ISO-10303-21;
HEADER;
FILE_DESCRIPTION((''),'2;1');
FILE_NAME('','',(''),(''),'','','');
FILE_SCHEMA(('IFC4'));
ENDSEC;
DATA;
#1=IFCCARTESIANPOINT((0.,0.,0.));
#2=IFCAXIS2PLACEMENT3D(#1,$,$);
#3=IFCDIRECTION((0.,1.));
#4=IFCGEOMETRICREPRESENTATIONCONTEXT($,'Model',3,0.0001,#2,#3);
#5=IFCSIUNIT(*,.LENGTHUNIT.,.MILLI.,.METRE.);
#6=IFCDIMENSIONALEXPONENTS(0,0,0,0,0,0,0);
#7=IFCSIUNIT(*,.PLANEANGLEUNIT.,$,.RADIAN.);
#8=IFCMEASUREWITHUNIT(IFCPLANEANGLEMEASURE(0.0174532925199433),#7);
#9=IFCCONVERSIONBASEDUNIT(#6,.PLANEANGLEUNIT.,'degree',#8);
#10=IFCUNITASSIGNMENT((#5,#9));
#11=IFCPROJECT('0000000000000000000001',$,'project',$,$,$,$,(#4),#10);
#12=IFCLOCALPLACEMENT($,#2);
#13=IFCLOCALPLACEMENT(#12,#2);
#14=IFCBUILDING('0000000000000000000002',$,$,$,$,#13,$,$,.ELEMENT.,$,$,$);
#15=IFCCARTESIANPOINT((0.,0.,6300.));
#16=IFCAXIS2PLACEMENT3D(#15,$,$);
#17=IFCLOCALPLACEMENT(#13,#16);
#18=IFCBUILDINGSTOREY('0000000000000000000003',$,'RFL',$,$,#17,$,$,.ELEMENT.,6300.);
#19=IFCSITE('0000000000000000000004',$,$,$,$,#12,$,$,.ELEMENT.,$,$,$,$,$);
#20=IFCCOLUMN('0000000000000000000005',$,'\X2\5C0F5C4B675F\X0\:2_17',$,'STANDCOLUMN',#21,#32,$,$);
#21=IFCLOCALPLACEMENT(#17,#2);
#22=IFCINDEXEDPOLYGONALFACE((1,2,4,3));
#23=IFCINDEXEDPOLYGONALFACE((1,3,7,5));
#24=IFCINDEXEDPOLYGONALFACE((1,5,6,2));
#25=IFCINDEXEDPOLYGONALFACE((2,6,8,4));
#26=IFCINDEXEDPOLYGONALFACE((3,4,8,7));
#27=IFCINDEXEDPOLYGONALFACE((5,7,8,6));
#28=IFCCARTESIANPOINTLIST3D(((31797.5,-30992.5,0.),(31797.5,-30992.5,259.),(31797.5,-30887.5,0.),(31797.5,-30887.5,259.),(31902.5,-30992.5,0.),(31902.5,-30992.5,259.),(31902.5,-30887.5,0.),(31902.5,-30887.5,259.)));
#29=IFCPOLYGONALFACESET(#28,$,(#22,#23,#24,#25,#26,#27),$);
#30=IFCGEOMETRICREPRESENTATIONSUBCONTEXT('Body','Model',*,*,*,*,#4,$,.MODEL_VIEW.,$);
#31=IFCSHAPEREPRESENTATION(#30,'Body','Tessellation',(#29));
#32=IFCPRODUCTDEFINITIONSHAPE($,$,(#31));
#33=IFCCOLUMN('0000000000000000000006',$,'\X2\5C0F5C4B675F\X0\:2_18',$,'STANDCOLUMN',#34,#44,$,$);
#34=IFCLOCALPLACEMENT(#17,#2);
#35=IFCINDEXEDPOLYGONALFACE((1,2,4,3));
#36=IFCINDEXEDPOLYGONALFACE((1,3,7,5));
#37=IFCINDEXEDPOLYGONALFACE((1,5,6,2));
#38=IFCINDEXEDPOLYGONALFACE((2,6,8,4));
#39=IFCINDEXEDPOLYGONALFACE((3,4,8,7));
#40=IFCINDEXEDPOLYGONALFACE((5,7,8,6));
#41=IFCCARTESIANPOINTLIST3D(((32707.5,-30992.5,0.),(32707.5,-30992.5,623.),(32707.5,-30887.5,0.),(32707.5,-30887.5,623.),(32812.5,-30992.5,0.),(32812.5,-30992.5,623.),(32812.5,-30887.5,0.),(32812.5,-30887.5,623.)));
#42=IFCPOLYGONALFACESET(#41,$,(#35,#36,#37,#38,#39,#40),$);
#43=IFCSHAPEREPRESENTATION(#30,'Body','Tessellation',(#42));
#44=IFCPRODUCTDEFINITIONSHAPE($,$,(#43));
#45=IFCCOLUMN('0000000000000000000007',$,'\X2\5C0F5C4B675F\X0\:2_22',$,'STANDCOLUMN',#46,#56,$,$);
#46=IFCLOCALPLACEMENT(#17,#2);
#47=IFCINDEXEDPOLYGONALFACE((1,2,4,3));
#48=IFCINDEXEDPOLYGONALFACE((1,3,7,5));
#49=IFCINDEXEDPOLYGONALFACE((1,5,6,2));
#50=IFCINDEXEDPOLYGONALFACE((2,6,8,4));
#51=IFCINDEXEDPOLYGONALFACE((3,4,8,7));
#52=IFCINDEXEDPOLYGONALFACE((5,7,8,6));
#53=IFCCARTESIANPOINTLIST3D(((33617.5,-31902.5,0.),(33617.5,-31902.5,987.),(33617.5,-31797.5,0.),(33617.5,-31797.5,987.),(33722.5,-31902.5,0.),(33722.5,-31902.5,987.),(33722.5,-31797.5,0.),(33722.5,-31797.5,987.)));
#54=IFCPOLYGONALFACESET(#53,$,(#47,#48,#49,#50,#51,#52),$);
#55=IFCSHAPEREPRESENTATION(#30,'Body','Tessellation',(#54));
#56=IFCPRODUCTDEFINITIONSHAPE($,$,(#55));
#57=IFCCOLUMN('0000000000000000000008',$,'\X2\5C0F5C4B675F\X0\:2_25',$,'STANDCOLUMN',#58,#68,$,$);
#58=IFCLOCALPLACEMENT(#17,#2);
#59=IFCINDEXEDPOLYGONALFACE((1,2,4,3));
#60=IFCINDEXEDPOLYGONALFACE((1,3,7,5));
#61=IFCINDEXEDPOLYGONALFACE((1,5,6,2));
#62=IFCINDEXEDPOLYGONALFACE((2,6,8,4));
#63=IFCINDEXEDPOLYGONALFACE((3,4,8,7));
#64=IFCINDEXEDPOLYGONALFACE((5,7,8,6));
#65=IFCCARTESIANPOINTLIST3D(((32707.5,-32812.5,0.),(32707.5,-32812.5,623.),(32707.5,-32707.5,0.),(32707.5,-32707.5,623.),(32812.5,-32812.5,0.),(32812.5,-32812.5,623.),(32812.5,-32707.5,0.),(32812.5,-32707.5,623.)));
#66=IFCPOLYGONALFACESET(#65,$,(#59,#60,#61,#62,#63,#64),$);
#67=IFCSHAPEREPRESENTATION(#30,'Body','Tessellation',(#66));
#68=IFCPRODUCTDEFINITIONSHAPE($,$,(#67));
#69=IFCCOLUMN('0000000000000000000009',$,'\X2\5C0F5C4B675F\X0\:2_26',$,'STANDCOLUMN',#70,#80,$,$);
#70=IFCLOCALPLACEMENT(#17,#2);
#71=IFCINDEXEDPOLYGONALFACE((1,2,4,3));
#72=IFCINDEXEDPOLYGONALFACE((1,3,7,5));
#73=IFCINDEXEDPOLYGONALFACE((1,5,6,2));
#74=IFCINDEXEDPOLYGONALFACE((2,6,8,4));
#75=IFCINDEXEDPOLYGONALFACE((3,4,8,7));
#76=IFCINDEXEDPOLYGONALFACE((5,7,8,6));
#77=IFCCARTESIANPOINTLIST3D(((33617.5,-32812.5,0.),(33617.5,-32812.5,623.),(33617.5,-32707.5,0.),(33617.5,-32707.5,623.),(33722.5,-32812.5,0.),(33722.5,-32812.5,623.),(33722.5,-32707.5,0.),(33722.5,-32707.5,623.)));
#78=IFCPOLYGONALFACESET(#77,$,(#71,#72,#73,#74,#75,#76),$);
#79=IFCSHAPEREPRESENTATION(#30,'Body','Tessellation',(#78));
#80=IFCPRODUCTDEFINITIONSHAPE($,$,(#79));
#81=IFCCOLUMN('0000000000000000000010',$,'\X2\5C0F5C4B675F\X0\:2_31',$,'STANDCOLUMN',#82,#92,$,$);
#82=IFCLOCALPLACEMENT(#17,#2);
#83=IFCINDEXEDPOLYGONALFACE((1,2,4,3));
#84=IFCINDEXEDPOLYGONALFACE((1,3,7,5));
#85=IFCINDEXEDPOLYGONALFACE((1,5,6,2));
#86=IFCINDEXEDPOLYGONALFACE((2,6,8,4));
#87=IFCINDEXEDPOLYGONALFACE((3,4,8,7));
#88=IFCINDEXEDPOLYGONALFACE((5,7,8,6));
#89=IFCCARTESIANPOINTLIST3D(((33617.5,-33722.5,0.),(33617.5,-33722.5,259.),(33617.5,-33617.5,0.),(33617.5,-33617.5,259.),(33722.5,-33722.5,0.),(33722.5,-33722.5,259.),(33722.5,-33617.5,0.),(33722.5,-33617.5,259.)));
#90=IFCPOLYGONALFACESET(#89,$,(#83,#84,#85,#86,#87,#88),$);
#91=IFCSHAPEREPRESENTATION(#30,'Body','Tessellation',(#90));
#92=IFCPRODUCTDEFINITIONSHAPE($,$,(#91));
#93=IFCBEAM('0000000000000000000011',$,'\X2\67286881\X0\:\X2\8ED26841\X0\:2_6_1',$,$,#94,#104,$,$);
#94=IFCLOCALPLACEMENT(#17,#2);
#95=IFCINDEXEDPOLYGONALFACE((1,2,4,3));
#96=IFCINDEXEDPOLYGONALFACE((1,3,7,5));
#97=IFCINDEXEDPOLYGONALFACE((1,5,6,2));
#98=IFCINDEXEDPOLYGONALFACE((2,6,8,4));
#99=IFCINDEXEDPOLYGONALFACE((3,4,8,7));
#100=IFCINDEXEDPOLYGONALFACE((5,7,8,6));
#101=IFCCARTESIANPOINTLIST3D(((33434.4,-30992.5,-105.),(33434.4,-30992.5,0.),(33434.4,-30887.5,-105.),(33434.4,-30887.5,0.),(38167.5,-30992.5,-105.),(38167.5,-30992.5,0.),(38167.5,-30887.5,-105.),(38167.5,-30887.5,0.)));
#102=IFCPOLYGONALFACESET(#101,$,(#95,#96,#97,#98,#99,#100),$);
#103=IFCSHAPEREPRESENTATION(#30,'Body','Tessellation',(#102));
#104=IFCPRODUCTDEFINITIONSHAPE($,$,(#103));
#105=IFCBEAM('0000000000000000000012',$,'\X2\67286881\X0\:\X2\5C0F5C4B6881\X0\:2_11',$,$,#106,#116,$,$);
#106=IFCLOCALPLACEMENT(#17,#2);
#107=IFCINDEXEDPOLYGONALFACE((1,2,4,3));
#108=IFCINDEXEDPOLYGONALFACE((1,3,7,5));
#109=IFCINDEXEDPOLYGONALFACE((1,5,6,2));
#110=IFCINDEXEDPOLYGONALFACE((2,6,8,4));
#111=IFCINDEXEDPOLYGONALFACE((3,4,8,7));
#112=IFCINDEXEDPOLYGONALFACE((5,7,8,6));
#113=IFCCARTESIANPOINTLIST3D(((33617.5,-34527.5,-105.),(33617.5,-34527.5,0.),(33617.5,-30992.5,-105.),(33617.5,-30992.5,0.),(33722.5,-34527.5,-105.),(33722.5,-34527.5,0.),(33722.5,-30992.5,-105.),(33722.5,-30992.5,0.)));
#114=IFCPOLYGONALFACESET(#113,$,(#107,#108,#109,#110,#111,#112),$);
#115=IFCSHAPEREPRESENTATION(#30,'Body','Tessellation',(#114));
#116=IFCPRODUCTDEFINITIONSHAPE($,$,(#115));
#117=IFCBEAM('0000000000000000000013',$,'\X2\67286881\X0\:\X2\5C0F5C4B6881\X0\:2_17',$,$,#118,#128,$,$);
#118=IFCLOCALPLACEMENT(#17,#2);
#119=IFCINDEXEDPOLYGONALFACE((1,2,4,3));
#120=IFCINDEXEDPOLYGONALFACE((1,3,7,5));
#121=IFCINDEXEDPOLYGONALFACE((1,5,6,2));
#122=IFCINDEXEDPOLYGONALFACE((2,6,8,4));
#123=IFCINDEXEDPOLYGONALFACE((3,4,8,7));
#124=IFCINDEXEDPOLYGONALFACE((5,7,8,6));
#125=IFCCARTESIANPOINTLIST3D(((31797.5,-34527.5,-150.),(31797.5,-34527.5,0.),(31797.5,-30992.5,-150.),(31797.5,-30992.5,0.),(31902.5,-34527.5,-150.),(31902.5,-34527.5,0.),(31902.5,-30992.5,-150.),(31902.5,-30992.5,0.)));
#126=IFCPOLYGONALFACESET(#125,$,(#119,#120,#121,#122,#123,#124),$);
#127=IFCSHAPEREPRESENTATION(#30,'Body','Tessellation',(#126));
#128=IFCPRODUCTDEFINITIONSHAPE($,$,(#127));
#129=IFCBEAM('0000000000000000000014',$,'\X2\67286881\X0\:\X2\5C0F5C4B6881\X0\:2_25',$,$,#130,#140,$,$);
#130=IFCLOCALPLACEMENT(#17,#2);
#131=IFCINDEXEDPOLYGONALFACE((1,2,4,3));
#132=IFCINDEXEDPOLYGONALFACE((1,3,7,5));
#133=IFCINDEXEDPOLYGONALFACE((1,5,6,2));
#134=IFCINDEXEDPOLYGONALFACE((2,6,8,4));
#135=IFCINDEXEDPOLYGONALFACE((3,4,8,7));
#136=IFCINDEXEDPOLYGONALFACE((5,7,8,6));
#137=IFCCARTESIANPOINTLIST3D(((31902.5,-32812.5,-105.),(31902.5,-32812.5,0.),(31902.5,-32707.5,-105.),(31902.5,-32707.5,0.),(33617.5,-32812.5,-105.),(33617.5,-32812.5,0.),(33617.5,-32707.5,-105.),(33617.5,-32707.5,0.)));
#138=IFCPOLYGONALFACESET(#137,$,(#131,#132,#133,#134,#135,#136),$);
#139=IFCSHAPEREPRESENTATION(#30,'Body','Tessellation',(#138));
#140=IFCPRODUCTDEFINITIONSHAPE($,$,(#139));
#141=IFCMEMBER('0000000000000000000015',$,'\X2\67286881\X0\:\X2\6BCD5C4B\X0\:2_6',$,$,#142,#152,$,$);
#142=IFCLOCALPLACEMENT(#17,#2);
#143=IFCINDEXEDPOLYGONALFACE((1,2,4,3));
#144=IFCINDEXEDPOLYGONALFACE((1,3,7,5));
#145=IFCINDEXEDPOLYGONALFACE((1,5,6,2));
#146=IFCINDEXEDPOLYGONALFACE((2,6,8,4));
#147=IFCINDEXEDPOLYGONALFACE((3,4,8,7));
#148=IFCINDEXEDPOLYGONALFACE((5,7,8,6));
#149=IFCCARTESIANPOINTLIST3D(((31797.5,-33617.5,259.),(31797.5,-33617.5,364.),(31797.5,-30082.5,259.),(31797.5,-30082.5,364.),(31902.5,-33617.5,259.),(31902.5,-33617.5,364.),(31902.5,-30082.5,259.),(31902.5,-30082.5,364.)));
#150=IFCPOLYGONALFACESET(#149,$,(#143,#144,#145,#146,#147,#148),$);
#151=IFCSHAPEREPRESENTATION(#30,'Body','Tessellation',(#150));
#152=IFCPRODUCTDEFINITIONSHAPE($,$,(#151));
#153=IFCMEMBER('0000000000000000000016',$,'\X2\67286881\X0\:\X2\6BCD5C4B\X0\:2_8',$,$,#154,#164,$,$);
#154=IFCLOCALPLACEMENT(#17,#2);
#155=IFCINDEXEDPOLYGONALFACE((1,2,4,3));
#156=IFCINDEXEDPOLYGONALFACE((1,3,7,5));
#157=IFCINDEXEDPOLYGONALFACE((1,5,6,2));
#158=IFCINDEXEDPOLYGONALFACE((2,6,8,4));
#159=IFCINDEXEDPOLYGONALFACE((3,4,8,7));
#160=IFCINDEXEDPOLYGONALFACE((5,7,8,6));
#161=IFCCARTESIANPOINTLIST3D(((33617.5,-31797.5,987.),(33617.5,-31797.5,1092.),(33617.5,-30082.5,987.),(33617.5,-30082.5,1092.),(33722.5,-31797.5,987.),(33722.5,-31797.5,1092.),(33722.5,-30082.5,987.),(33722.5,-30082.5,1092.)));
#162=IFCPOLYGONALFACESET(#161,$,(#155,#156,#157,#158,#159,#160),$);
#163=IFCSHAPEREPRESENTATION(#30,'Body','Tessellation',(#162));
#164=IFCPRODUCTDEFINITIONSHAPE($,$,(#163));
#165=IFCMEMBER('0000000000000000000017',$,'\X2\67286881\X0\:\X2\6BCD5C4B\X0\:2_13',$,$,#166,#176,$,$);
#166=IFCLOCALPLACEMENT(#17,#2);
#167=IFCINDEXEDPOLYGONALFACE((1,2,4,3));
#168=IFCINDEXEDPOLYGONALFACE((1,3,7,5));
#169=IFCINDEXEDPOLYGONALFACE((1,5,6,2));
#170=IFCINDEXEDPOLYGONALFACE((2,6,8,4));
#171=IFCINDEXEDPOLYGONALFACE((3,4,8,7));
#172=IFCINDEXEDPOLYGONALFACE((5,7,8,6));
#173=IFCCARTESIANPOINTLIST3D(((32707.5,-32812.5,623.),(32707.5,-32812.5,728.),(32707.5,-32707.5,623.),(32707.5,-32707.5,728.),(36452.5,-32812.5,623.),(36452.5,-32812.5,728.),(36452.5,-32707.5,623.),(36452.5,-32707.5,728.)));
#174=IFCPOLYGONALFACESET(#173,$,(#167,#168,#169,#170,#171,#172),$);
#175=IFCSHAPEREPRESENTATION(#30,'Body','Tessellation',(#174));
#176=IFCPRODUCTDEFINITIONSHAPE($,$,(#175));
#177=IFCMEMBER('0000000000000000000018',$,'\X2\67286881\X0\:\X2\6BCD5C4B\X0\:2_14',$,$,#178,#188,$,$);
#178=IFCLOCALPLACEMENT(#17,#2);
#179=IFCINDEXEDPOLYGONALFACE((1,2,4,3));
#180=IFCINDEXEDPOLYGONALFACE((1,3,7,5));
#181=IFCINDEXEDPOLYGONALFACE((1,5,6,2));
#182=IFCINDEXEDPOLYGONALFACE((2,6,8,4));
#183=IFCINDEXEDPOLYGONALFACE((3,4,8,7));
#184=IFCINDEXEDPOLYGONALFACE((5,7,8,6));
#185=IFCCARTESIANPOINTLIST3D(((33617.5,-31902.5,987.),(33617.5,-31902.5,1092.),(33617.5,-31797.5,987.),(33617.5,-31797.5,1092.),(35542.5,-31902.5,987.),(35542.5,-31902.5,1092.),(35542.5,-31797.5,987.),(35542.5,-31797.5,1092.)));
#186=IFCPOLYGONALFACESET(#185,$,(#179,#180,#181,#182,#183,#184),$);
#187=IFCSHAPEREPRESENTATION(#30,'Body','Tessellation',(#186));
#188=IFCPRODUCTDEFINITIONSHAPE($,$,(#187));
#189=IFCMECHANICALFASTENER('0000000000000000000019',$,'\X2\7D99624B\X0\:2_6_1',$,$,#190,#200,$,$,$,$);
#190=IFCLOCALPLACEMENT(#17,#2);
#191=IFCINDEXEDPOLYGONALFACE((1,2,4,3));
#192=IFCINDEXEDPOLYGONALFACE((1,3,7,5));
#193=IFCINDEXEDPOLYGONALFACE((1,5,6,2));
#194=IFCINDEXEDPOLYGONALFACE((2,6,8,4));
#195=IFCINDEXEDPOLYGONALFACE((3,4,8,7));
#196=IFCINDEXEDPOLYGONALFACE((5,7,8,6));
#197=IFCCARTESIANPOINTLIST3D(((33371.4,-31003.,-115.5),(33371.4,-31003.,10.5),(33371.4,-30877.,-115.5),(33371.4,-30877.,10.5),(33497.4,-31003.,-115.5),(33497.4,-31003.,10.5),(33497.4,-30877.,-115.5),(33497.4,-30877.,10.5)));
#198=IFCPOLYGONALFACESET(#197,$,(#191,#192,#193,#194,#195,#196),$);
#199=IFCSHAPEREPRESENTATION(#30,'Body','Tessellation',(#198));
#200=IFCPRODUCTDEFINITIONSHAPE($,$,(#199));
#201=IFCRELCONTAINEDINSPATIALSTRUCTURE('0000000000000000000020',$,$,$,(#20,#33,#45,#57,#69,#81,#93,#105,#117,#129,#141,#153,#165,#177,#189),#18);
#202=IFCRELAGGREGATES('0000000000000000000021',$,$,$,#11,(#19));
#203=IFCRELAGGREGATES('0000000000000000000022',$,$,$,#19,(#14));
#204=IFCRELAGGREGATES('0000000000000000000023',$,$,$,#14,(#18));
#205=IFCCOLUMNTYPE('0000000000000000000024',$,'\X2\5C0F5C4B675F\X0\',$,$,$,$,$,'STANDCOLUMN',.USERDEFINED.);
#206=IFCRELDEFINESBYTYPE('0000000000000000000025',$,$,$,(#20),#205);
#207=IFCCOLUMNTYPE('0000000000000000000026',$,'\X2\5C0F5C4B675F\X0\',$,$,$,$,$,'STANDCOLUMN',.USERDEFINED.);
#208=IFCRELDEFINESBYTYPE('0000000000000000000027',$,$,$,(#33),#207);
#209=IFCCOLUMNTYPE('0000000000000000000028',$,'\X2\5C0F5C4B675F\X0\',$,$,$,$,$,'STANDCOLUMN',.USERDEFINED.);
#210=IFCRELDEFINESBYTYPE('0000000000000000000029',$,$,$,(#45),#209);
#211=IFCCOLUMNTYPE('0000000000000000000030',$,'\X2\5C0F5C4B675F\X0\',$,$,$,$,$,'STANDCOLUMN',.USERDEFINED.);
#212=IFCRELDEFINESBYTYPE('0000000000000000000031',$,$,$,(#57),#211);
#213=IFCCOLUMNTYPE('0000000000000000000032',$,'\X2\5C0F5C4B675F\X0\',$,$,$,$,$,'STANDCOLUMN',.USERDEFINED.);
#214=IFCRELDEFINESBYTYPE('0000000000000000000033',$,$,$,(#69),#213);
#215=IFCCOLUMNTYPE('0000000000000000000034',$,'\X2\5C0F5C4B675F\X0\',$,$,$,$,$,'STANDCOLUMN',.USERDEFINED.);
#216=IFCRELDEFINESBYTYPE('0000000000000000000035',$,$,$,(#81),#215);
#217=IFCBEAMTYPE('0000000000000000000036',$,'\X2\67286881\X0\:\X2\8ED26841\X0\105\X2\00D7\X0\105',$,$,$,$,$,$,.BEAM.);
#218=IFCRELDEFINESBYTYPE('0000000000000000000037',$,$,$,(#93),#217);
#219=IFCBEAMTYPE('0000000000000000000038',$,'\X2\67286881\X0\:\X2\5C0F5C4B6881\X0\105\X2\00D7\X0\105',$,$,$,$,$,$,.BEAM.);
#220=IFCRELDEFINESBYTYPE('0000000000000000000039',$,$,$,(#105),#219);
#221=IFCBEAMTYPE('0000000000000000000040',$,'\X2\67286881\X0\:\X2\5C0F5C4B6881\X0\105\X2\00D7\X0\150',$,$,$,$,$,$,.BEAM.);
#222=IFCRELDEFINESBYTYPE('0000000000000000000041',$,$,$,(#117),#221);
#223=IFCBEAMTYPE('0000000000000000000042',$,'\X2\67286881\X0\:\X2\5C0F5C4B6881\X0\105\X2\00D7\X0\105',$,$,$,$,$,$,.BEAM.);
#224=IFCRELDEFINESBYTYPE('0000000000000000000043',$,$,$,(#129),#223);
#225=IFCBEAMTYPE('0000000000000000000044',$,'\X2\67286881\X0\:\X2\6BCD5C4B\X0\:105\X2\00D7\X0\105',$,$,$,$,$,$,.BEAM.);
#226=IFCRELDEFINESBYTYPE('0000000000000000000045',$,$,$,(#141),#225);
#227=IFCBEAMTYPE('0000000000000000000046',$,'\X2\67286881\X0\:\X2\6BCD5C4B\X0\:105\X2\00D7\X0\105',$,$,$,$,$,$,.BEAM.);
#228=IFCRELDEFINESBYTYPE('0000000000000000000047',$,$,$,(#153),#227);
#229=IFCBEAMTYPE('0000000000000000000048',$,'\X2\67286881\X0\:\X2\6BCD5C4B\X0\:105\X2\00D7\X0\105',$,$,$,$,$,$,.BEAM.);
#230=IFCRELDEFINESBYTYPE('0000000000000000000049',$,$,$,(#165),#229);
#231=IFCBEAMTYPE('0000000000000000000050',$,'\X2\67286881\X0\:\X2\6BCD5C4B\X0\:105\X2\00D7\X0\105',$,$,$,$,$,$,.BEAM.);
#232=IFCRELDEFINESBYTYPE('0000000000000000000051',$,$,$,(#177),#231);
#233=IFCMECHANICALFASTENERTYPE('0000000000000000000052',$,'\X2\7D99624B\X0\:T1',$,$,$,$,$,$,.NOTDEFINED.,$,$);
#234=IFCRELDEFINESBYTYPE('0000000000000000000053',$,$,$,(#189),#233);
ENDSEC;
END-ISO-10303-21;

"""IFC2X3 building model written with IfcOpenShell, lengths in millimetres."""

from ifc_helpers import new_model, entity, si_unit, converted_unit, direction, frame, origin, origin_with_axes, origin_2d, place, context, subcontext, project, spatial, rectangle, extrude, type_object, element, save


model = new_model("IFC2X3")

# Units and contexts
model_context = context("Model", 3, precision=0.0001, world=origin(), true_north=direction((0.0, 1.0)))
body_context = subcontext(model_context, "Body", "Model", "MODEL_VIEW")
ifc_project = project(units=[si_unit("LENGTHUNIT", "METRE", prefix="MILLI"), converted_unit("PLANEANGLEUNIT", "degree", entity("IfcPlaneAngleMeasure", 0.0174532925199433), si_unit("PLANEANGLEUNIT", "RADIAN"), dimensions=[0, 0, 0, 0, 0, 0, 0])], contexts=[model_context])

# Site, building, storey
site_placement = place(None, origin())
site = spatial("IfcSite", under=ifc_project, at=site_placement, CompositionType="ELEMENT")
building_placement = place(site_placement, origin())
building = spatial("IfcBuilding", under=site, at=building_placement, CompositionType="ELEMENT")
storey_placement = place(building_placement, frame((0.0, 0.0, 6300.0)))
storey = spatial("IfcBuildingStorey", under=building, at=storey_placement, Name="RFL", CompositionType="ELEMENT", Elevation=6300.0)

# Columns
column_type_1 = type_object("IfcColumnType", Name="小屋束", ElementType="STANDCOLUMN", PredefinedType="USERDEFINED")
column_1_placement = place(storey_placement, frame((31850.0, -30940.0, 0.0)))
element("IfcColumn", 1, at=column_1_placement, inside=storey, type_object=column_type_1, Name="小屋束:2_17", ObjectType="STANDCOLUMN", context=body_context, shape_type="SweptSolid", body=[
    extrude(rectangle(XDim=105.0, YDim=105.0, at=origin_2d()), origin_with_axes(), (0.0, 0.0, 1.0), 259.0),
])
column_type_2 = type_object("IfcColumnType", Name="小屋束", ElementType="STANDCOLUMN", PredefinedType="USERDEFINED")
column_2_placement = place(storey_placement, frame((32760.0, -30940.0, 0.0)))
element("IfcColumn", 2, at=column_2_placement, inside=storey, type_object=column_type_2, Name="小屋束:2_18", ObjectType="STANDCOLUMN", context=body_context, shape_type="SweptSolid", body=[
    extrude(rectangle(XDim=105.0, YDim=105.0, at=origin_2d()), origin_with_axes(), (0.0, 0.0, 1.0), 623.0),
])
column_type_3 = type_object("IfcColumnType", Name="小屋束", ElementType="STANDCOLUMN", PredefinedType="USERDEFINED")
column_3_placement = place(storey_placement, frame((33670.0, -31850.0, 0.0)))
element("IfcColumn", 3, at=column_3_placement, inside=storey, type_object=column_type_3, Name="小屋束:2_22", ObjectType="STANDCOLUMN", context=body_context, shape_type="SweptSolid", body=[
    extrude(rectangle(XDim=105.0, YDim=105.0, at=origin_2d()), origin_with_axes(), (0.0, 0.0, 1.0), 987.0),
])
column_type_4 = type_object("IfcColumnType", Name="小屋束", ElementType="STANDCOLUMN", PredefinedType="USERDEFINED")
column_4_placement = place(storey_placement, frame((32760.0, -32760.0, 0.0)))
element("IfcColumn", 4, at=column_4_placement, inside=storey, type_object=column_type_4, Name="小屋束:2_25", ObjectType="STANDCOLUMN", context=body_context, shape_type="SweptSolid", body=[
    extrude(rectangle(XDim=105.0, YDim=105.0, at=origin_2d()), origin_with_axes(), (0.0, 0.0, 1.0), 623.0),
])
column_type_5 = type_object("IfcColumnType", Name="小屋束", ElementType="STANDCOLUMN", PredefinedType="USERDEFINED")
column_5_placement = place(storey_placement, frame((33670.0, -32760.0, 0.0)))
element("IfcColumn", 5, at=column_5_placement, inside=storey, type_object=column_type_5, Name="小屋束:2_26", ObjectType="STANDCOLUMN", context=body_context, shape_type="SweptSolid", body=[
    extrude(rectangle(XDim=105.0, YDim=105.0, at=origin_2d()), origin_with_axes(), (0.0, 0.0, 1.0), 623.0),
])
column_type_6 = type_object("IfcColumnType", Name="小屋束", ElementType="STANDCOLUMN", PredefinedType="USERDEFINED")
column_6_placement = place(storey_placement, frame((33670.0, -33670.0, 0.0)))
element("IfcColumn", 6, at=column_6_placement, inside=storey, type_object=column_type_6, Name="小屋束:2_31", ObjectType="STANDCOLUMN", context=body_context, shape_type="SweptSolid", body=[
    extrude(rectangle(XDim=105.0, YDim=105.0, at=origin_2d()), origin_with_axes(), (0.0, 0.0, 1.0), 259.0),
])

# Beams
beam_type_1 = type_object("IfcBeamType", Name="木梁:軒桁105×105", PredefinedType="BEAM")
beam_1_placement = place(storey_placement, frame((33434.3, -30940.0, -52.5), z_axis=(1.0, 0.0, 0.0), x_axis=(0.0, 1.0, 0.0)))
element("IfcBeam", 7, at=beam_1_placement, inside=storey, type_object=beam_type_1, Name="木梁:軒桁:2_6_1", context=body_context, shape_type="SweptSolid", body=[
    extrude(rectangle(XDim=105.0, YDim=105.0, at=origin_2d()), origin_with_axes(), (0.0, 0.0, 1.0), 4733.1),
])
beam_type_2 = type_object("IfcBeamType", Name="木梁:小屋梁105×105", PredefinedType="BEAM")
beam_2_placement = place(storey_placement, frame((33670.0, -30992.5, -52.5), z_axis=(0.0, -1.0, 0.0), x_axis=(1.0, 0.0, 0.0)))
element("IfcBeam", 8, at=beam_2_placement, inside=storey, type_object=beam_type_2, Name="木梁:小屋梁:2_11", context=body_context, shape_type="SweptSolid", body=[
    extrude(rectangle(XDim=105.0, YDim=105.0, at=origin_2d()), origin_with_axes(), (0.0, 0.0, 1.0), 3535.0),
])
beam_type_3 = type_object("IfcBeamType", Name="木梁:小屋梁105×150", PredefinedType="BEAM")
beam_3_placement = place(storey_placement, frame((31850.0, -30992.5, -75.0), z_axis=(0.0, -1.0, 0.0), x_axis=(1.0, 0.0, 0.0)))
element("IfcBeam", 9, at=beam_3_placement, inside=storey, type_object=beam_type_3, Name="木梁:小屋梁:2_17", context=body_context, shape_type="SweptSolid", body=[
    extrude(rectangle(XDim=105.0, YDim=150.0, at=origin_2d()), origin_with_axes(), (0.0, 0.0, 1.0), 3535.0),
])
beam_type_4 = type_object("IfcBeamType", Name="木梁:小屋梁105×105", PredefinedType="BEAM")
beam_4_placement = place(storey_placement, frame((31902.5, -32760.0, -52.5), z_axis=(1.0, 0.0, 0.0), x_axis=(0.0, 1.0, 0.0)))
element("IfcBeam", 10, at=beam_4_placement, inside=storey, type_object=beam_type_4, Name="木梁:小屋梁:2_25", context=body_context, shape_type="SweptSolid", body=[
    extrude(rectangle(XDim=105.0, YDim=105.0, at=origin_2d()), origin_with_axes(), (0.0, 0.0, 1.0), 1715.0),
])

# Members
beam_type_5 = type_object("IfcBeamType", Name="木梁:母屋:105×105", PredefinedType="BEAM")
member_1_placement = place(storey_placement, frame((31850.0, -30082.5, 311.5), z_axis=(0.0, -1.0, 0.0), x_axis=(-1.0, 0.0, 0.0)))
element("IfcMember", 11, at=member_1_placement, inside=storey, type_object=beam_type_5, Name="木梁:母屋:2_6", context=body_context, shape_type="SweptSolid", body=[
    extrude(rectangle(XDim=105.0, YDim=105.0, at=origin_2d()), origin_with_axes(), (0.0, 0.0, 1.0), 3535.0),
])
beam_type_6 = type_object("IfcBeamType", Name="木梁:母屋:105×105", PredefinedType="BEAM")
member_2_placement = place(storey_placement, frame((33670.0, -30082.5, 1039.5), z_axis=(0.0, -1.0, 0.0), x_axis=(-1.0, 0.0, 0.0)))
element("IfcMember", 12, at=member_2_placement, inside=storey, type_object=beam_type_6, Name="木梁:母屋:2_8", context=body_context, shape_type="SweptSolid", body=[
    extrude(rectangle(XDim=105.0, YDim=105.0, at=origin_2d()), origin_with_axes(), (0.0, 0.0, 1.0), 1715.0),
])
beam_type_7 = type_object("IfcBeamType", Name="木梁:母屋:105×105", PredefinedType="BEAM")
member_3_placement = place(storey_placement, frame((32707.5, -32760.0, 675.5), z_axis=(1.0, 0.0, 0.0), x_axis=(0.0, -1.0, 0.0)))
element("IfcMember", 13, at=member_3_placement, inside=storey, type_object=beam_type_7, Name="木梁:母屋:2_13", context=body_context, shape_type="SweptSolid", body=[
    extrude(rectangle(XDim=105.0, YDim=105.0, at=origin_2d()), origin_with_axes(), (0.0, 0.0, 1.0), 3745.0),
])
beam_type_8 = type_object("IfcBeamType", Name="木梁:母屋:105×105", PredefinedType="BEAM")
member_4_placement = place(storey_placement, frame((33617.5, -31850.0, 1039.5), z_axis=(1.0, 0.0, 0.0), x_axis=(0.0, -1.0, 0.0)))
element("IfcMember", 14, at=member_4_placement, inside=storey, type_object=beam_type_8, Name="木梁:母屋:2_14", context=body_context, shape_type="SweptSolid", body=[
    extrude(rectangle(XDim=105.0, YDim=105.0, at=origin_2d()), origin_with_axes(), (0.0, 0.0, 1.0), 1925.0),
])

# Mechanical fastener
mechanical_fastener_type_1 = type_object("IfcMechanicalFastenerType", Name="継手:T1")
mechanical_fastener_1_placement = place(storey_placement, frame((33434.3, -30940.0, -115.5)))
element("IfcMechanicalFastener", 15, at=mechanical_fastener_1_placement, inside=storey, type_object=mechanical_fastener_type_1, Name="継手:2_6_1", context=body_context, shape_type="SweptSolid", body=[
    extrude(rectangle(XDim=126.0, YDim=126.0, at=origin_2d()), origin_with_axes(), (0.0, 0.0, 1.0), 126.0),
])

save(model, "model.ifc")
